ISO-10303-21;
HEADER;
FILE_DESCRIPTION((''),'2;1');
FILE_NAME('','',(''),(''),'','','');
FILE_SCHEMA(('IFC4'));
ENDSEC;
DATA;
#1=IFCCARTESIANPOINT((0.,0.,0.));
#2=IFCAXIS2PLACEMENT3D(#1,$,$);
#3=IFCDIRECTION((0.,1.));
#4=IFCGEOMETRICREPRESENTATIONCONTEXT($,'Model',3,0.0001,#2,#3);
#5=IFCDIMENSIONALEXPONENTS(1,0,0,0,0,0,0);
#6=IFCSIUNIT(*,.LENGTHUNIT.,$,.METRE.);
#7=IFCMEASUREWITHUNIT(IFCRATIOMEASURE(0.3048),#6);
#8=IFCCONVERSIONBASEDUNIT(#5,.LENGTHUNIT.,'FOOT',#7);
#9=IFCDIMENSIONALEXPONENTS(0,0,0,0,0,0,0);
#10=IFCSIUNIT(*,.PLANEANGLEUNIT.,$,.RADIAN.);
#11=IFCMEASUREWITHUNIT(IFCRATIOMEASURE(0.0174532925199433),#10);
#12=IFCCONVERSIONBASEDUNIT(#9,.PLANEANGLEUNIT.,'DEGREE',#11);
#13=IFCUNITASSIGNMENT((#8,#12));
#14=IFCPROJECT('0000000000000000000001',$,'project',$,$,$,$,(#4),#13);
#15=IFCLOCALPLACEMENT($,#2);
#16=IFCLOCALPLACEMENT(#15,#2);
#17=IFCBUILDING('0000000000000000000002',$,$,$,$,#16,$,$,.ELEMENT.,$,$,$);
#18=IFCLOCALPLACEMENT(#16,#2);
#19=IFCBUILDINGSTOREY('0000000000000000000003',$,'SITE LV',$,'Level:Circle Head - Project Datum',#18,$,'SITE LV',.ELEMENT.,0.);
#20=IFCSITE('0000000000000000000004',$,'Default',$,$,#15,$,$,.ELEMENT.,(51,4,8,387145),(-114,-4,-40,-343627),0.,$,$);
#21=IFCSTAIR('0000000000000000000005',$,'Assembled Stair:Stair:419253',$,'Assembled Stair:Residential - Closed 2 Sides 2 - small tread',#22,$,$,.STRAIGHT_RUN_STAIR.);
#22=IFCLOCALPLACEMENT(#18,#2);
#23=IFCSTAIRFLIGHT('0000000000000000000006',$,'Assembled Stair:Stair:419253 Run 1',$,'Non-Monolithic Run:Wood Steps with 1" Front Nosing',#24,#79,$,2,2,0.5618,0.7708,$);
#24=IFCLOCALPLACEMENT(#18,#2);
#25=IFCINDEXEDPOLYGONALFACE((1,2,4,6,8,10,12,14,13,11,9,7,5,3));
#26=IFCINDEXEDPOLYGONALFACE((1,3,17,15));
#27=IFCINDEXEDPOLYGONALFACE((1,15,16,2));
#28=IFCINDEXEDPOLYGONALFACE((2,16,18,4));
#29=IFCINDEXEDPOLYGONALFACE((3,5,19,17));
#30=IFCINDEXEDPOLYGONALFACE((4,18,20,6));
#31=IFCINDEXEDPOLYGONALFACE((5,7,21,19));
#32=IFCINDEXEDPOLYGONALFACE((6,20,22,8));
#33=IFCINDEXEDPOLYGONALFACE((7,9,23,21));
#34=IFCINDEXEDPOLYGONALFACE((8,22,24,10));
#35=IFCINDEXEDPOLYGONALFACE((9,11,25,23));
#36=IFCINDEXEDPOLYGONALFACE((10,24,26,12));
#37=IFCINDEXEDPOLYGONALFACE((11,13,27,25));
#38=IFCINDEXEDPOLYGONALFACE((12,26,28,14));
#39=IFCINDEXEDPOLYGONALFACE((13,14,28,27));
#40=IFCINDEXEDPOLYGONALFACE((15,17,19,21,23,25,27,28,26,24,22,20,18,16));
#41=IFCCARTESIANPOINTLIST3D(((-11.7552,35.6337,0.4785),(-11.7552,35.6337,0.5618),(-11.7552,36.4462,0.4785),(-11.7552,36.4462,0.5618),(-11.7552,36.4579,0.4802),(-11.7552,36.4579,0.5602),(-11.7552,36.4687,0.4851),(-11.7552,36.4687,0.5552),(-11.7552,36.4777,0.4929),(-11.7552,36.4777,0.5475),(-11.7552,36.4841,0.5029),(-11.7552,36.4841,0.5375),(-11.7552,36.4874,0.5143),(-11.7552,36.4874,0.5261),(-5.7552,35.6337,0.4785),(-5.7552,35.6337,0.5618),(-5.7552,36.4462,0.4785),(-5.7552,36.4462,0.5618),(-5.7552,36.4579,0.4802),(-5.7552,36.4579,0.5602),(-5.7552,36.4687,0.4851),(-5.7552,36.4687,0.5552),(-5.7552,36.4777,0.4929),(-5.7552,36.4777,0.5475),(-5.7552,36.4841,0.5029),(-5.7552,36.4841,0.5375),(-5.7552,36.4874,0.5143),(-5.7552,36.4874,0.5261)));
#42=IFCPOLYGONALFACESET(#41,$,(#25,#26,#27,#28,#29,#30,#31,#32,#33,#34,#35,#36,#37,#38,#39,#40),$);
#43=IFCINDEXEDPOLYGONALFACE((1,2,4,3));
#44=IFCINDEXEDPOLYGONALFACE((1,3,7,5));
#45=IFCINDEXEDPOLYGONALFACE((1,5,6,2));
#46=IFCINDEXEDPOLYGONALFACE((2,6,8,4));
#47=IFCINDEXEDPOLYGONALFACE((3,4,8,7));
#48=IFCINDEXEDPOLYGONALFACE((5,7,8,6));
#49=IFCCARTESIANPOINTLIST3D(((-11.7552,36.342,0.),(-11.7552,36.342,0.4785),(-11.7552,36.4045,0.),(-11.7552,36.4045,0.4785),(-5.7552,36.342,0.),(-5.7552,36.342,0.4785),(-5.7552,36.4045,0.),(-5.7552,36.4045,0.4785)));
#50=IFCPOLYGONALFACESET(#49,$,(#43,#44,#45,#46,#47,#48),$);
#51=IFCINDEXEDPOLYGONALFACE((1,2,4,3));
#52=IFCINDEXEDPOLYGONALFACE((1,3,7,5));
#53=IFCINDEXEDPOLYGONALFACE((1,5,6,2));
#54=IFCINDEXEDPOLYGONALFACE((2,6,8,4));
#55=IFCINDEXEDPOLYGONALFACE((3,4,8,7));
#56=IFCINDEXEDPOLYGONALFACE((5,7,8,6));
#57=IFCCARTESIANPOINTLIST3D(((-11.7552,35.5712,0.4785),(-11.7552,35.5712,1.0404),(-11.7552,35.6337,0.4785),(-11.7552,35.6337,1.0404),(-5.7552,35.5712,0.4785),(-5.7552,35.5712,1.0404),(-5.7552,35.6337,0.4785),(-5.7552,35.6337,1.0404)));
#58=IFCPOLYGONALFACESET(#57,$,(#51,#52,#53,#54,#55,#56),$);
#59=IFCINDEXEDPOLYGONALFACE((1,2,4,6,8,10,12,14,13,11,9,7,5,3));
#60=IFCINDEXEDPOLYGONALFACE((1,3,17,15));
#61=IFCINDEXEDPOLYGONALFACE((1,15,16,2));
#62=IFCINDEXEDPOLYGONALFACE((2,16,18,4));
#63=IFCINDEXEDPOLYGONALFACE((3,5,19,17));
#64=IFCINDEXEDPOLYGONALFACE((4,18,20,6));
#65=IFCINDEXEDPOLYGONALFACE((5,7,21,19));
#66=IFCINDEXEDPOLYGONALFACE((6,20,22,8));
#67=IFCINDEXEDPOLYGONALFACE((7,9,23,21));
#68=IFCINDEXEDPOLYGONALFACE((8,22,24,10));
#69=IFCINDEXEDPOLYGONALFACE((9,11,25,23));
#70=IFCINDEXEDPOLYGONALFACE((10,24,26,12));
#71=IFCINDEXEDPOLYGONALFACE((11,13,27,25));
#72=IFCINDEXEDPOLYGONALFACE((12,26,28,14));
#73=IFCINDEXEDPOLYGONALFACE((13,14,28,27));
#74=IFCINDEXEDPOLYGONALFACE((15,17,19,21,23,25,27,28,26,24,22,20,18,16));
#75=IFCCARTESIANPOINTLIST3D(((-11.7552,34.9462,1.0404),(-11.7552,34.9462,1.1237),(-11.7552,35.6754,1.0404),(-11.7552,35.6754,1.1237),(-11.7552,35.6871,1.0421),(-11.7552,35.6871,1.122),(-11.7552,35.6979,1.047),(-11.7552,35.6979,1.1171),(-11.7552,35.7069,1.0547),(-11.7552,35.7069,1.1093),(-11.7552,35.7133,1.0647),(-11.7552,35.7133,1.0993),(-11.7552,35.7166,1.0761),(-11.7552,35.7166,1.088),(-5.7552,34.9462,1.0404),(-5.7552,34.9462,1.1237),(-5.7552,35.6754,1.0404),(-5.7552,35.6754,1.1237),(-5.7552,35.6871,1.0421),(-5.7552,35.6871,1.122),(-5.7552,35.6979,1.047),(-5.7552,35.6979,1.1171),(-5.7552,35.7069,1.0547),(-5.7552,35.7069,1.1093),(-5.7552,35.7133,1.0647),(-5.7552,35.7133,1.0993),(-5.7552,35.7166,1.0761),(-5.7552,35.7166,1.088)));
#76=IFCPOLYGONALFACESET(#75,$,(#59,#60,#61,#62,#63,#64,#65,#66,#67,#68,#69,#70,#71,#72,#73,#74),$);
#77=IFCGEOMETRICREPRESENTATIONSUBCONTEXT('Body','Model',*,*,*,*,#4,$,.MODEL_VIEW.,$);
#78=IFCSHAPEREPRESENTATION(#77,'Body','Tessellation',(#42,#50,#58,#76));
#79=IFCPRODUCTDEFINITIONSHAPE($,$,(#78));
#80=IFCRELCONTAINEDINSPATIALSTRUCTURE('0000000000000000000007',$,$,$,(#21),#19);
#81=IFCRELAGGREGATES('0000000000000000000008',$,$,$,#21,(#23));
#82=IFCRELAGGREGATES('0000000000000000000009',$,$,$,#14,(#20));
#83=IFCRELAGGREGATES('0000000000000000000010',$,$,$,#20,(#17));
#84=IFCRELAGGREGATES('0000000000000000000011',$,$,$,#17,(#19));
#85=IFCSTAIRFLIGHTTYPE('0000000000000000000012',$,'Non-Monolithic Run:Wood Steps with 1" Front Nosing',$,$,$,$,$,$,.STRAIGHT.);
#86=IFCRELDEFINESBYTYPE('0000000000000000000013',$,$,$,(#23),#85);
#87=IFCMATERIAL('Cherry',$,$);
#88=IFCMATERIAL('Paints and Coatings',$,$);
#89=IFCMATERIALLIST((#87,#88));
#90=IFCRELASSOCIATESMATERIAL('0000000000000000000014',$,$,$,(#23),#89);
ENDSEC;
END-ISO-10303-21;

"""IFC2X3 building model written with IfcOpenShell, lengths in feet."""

from ifc_helpers import new_model, entity, si_unit, converted_unit, direction, frame, frame_2d, origin, origin_2d_with_axis, place, context, subcontext, project, spatial, polyline, circle_curve, parameter, trimmed, segment, composite_curve, rectangle, outline, extrude, material, material_list, type_object, element, aggregate, save


model = new_model("IFC2X3")

# Units and contexts
model_context = context("Model", 3, precision=0.0001, world=origin(), true_north=direction((0.0, 1.0)))
body_context = subcontext(model_context, "Body", "Model", "MODEL_VIEW")
ifc_project = project(units=[converted_unit("LENGTHUNIT", "FOOT", entity("IfcRatioMeasure", 0.3048), si_unit("LENGTHUNIT", "METRE"), dimensions=[1, 0, 0, 0, 0, 0, 0]), converted_unit("PLANEANGLEUNIT", "DEGREE", entity("IfcRatioMeasure", 0.0174532925199433), si_unit("PLANEANGLEUNIT", "RADIAN"), dimensions=[0, 0, 0, 0, 0, 0, 0])], contexts=[model_context])

# Site, building, storey
site_placement = place(None, origin())
site = spatial("IfcSite", under=ifc_project, at=site_placement, Name="Default", CompositionType="ELEMENT", RefLatitude=(51, 4, 8, 387145), RefLongitude=(-114, -4, -40, -343627), RefElevation=0.0)
building_placement = place(site_placement, origin())
building = spatial("IfcBuilding", under=site, at=building_placement, CompositionType="ELEMENT")
storey_placement = place(building_placement, origin())
storey = spatial("IfcBuildingStorey", under=building, at=storey_placement, Name="SITE LV", ObjectType="Level:Circle Head - Project Datum", LongName="SITE LV", CompositionType="ELEMENT", Elevation=0.0)

# Stair
stair_placement = place(storey_placement, origin())
stair = element("IfcStair", 1, at=stair_placement, inside=storey, Name="Assembled Stair:Stair:419253", ObjectType="Assembled Stair:Residential - Closed 2 Sides 2 - small tread", ShapeType="STRAIGHT_RUN_STAIR")
ifc_material_1 = material(Name="Paints and Coatings")

# Stair flight
ifc_material_2 = material(Name="Cherry")
ifc_material_list = material_list([ifc_material_2, ifc_material_1])
stair_flight_type = type_object("IfcStairFlightType", Name="Non-Monolithic Run:Wood Steps with 1\" Front Nosing", PredefinedType="STRAIGHT")
stair_flight_placement = place(stair_placement, origin())
stair_flight = element("IfcStairFlight", 2, at=stair_flight_placement, type_object=stair_flight_type, material=ifc_material_list, Name="Assembled Stair:Stair:419253 Run 1", ObjectType="Non-Monolithic Run:Wood Steps with 1\" Front Nosing", NumberOfRiser=2, NumberOfTreads=2, RiserHeight=0.5618, TreadLength=0.7708, context=body_context, shape_type="SweptSolid", body=[
    extrude(outline(composite_curve([segment(polyline([(-0.0417, -0.4063), (0.0417, -0.4063)]), True, "CONTINUOUS"), segment(polyline([(0.0417, -0.4063), (0.0417, 0.4063)]), True, "CONTINUOUS"), segment(trimmed(circle_curve(frame_2d((0.0, 0.4063), x_axis=(0.0, -1.0)), 0.0417), [parameter(90.0)], [parameter(270.0)], True, "PARAMETER"), True, "CONTINUOUS"), segment(polyline([(-0.0417, 0.4063), (-0.0417, -0.4063)]), True, "CONTINUOUS")], self_intersect=False)), frame((-11.7552, 36.0399, 0.5202), z_axis=(1.0, 0.0, 0.0), x_axis=(0.0, 0.0, -1.0)), (0.0, 0.0, 1.0), 6.0),
    extrude(rectangle(XDim=6.0, YDim=0.0625, at=origin_2d_with_axis()), frame((-8.7552, 36.3733, 0.0)), (0.0, 0.0, 1.0), 0.4785),
    extrude(rectangle(XDim=6.0, YDim=0.0625, at=origin_2d_with_axis()), frame((-8.7552, 35.6024, 0.4785)), (0.0, 0.0, 1.0), 0.5618),
    extrude(outline(composite_curve([segment(polyline([(-0.0417, -0.3646), (0.0417, -0.3646)]), True, "CONTINUOUS"), segment(polyline([(0.0417, -0.3646), (0.0417, 0.3646)]), True, "CONTINUOUS"), segment(trimmed(circle_curve(frame_2d((0.0, 0.3646), x_axis=(0.0, -1.0)), 0.0417), [parameter(90.0)], [parameter(270.0)], True, "PARAMETER"), True, "CONTINUOUS"), segment(polyline([(-0.0417, 0.3646), (-0.0417, -0.3646)]), True, "CONTINUOUS")], self_intersect=False)), frame((-11.7552, 35.3108, 1.082), z_axis=(1.0, 0.0, 0.0), x_axis=(0.0, 0.0, -1.0)), (0.0, 0.0, 1.0), 6.0),
])
aggregate(stair, [stair_flight])

save(model, "model.ifc")
